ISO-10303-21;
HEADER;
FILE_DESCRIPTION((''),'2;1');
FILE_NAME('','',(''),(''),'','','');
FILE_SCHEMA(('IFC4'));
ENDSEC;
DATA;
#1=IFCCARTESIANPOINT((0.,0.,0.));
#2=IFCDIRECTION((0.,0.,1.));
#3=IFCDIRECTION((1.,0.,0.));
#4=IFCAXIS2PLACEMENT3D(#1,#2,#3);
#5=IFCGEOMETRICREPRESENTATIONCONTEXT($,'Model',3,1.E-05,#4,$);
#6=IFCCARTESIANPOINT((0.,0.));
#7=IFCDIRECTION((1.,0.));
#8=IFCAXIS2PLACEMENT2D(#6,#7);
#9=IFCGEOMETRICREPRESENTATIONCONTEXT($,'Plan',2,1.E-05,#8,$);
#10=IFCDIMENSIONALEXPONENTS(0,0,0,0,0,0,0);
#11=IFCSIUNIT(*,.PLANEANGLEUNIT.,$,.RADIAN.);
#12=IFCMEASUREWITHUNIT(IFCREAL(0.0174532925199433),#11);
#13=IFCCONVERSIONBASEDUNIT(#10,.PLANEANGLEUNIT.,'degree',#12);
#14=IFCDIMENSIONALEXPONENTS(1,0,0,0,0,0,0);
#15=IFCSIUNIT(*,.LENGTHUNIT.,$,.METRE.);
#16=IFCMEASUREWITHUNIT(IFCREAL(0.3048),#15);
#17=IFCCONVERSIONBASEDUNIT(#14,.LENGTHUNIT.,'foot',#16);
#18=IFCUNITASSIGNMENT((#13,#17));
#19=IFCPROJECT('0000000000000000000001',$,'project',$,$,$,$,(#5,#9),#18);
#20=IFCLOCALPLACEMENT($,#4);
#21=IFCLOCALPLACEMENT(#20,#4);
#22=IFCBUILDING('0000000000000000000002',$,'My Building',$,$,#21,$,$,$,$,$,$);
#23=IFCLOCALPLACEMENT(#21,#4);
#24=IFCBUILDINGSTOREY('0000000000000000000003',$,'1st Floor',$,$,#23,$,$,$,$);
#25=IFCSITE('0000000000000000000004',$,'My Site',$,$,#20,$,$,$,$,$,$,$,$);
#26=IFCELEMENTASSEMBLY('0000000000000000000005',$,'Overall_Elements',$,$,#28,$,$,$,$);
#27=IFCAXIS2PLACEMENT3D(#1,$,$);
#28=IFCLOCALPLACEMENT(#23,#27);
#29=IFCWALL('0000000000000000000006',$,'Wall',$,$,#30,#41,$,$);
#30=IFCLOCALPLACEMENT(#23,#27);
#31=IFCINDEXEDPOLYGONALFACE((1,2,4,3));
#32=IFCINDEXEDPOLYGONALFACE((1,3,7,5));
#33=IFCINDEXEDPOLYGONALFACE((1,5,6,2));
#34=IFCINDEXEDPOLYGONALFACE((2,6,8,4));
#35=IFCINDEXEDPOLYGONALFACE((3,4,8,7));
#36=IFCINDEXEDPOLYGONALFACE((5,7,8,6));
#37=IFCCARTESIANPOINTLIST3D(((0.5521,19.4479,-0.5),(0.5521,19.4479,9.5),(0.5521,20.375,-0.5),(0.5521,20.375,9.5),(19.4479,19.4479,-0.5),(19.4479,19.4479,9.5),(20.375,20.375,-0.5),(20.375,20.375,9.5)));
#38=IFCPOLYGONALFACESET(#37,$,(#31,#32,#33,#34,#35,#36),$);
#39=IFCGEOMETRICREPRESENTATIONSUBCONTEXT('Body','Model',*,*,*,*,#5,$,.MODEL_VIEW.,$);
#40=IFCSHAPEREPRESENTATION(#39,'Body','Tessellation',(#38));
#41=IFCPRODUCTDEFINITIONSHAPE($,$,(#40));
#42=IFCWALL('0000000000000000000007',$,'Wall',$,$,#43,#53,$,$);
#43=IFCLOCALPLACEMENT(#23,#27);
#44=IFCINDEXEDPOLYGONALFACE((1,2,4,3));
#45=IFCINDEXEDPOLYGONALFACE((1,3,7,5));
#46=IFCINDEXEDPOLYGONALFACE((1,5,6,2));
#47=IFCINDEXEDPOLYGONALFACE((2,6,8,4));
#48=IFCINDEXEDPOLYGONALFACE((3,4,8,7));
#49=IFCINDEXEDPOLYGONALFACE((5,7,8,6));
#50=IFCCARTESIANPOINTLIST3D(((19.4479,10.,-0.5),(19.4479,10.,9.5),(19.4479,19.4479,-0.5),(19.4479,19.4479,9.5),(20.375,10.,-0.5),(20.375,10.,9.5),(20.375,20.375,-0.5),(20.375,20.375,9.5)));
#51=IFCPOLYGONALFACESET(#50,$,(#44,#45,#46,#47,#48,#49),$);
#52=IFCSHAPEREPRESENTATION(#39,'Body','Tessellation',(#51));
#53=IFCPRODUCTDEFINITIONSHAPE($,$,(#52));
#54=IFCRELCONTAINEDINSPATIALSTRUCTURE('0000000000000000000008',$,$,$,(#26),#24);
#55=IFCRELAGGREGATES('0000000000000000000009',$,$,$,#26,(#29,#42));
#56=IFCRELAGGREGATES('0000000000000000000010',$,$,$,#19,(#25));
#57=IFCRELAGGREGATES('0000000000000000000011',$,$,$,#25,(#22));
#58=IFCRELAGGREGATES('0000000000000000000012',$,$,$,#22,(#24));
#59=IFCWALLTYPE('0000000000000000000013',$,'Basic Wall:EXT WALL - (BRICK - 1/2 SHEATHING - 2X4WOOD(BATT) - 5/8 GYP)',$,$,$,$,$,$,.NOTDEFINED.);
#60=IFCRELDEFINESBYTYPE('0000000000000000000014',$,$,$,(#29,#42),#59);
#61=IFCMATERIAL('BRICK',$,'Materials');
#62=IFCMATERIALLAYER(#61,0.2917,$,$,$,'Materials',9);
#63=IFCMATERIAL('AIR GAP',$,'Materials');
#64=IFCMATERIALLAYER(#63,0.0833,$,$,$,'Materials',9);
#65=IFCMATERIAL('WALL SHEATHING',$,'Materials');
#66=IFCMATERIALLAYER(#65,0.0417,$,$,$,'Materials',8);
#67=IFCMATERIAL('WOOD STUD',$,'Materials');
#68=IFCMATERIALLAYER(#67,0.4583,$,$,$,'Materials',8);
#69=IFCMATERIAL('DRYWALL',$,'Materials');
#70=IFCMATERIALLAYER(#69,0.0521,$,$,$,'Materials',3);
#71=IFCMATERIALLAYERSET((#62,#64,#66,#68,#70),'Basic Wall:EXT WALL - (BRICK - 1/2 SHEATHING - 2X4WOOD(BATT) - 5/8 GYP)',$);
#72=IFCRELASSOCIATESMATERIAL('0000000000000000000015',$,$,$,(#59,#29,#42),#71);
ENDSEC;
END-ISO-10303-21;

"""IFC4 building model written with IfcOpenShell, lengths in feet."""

from ifc_helpers import new_model, entity, si_unit, converted_unit, frame, origin_with_axes, origin_2d_with_axis, place, context, subcontext, project, spatial, indexed_curve, outline, extrude, clip, halfspace, material, layer, layer_set, layer_usage, type_object, element, aggregate, save


model = new_model("IFC4")

# Units and contexts
model_context = context("Model", 3, precision=1e-05, world=origin_with_axes())
plan_context = context("Plan", 2, precision=1e-05, world=origin_2d_with_axis())
body_context = subcontext(model_context, "Body", "Model", "MODEL_VIEW")
ifc_project = project(units=[converted_unit("PLANEANGLEUNIT", "degree", entity("IfcReal", 0.0174532925199433), si_unit("PLANEANGLEUNIT", "RADIAN"), dimensions=[0, 0, 0, 0, 0, 0, 0]), converted_unit("LENGTHUNIT", "foot", entity("IfcReal", 0.3048), si_unit("LENGTHUNIT", "METRE"), dimensions=[1, 0, 0, 0, 0, 0, 0])], contexts=[model_context, plan_context])

# Site, building, storey
site_placement = place(None, origin_with_axes())
site = spatial("IfcSite", under=ifc_project, at=site_placement, Name="My Site")
building_placement = place(site_placement, origin_with_axes())
building = spatial("IfcBuilding", under=site, at=building_placement, Name="My Building")
storey_placement = place(building_placement, origin_with_axes())
storey = spatial("IfcBuildingStorey", under=building, at=storey_placement, Name="1st Floor")

# Element assembly, walls
assembly_placement = place(storey_placement, frame((-0.0833, 0.0256, 9.5), z_axis=(0.0, 0.0, 1.0), x_axis=(1.0, 0.0, 0.0)))
assembly = element("IfcElementAssembly", 1, at=assembly_placement, inside=storey, Name="Overall_Elements")
ifc_material_1 = material(Name="DRYWALL", Category="Materials")
ifc_material_2 = material(Name="BRICK", Category="Materials")
ifc_layer_1 = layer(ifc_material_2, 0.2917, Category="Materials", Priority=9)
ifc_material_3 = material(Name="AIR GAP", Category="Materials")
ifc_layer_2 = layer(ifc_material_3, 0.0833, Category="Materials", Priority=9)
ifc_material_4 = material(Name="WALL SHEATHING", Category="Materials")
ifc_layer_3 = layer(ifc_material_4, 0.0417, Category="Materials", Priority=8)
ifc_material_5 = material(Name="WOOD STUD", Category="Materials")
ifc_layer_4 = layer(ifc_material_5, 0.4583, Category="Materials", Priority=8)
ifc_layer_5 = layer(ifc_material_1, 0.0521, Category="Materials", Priority=3)
ifc_layer_set_1 = layer_set([ifc_layer_1, ifc_layer_2, ifc_layer_3, ifc_layer_4, ifc_layer_5], Name="Basic Wall:EXT WALL - (BRICK - 1/2 SHEATHING - 2X4WOOD(BATT) - 5/8 GYP)")
wall_type_1 = type_object("IfcWallType", Name="Basic Wall:EXT WALL - (BRICK - 1/2 SHEATHING - 2X4WOOD(BATT) - 5/8 GYP)", PredefinedType="NOTDEFINED", material=ifc_layer_set_1)
ifc_layer_usage_1 = layer_usage(ifc_layer_set_1, "AXIS2", "POSITIVE", 0.0)
wall_1_placement = place(assembly_placement, frame((20.4583, 20.3494, -10.0), z_axis=(0.0, 0.0, 1.0), x_axis=(-1.0, 0.0, 0.0)))
wall_1 = element("IfcWall", 2, at=wall_1_placement, type_object=wall_type_1, material=ifc_layer_usage_1, Name="Wall", context=body_context, shape_type="Clipping", body=[
    clip(extrude(outline(indexed_curve([(0.0, 0.0), (0.0, 0.9271), (19.8229, 0.9271), (19.8229, 0.0), (0.0, 0.0)], self_intersect=False)), origin_with_axes(), (0.0, 0.0, 1.0), 10.0), halfspace(frame((0.0, 0.0, 0.5), z_axis=(-0.707107, 0.707106, 0.0), x_axis=(0.707106, 0.707107, 0.0)), False)),
])
ifc_layer_usage_2 = layer_usage(ifc_layer_set_1, "AXIS2", "POSITIVE", 0.0)
wall_2_placement = place(assembly_placement, frame((20.4583, 9.9744, -10.0), z_axis=(0.0, 0.0, 1.0), x_axis=(0.0, 1.0, 0.0)))
wall_2 = element("IfcWall", 3, at=wall_2_placement, type_object=wall_type_1, material=ifc_layer_usage_2, Name="Wall", context=body_context, shape_type="Clipping", body=[
    clip(extrude(outline(indexed_curve([(0.0, 0.0), (0.0, 0.9271), (10.375, 0.9271), (10.375, 0.0), (0.0, 0.0)], self_intersect=False)), origin_with_axes(), (0.0, 0.0, 1.0), 10.0), halfspace(frame((10.375, 0.0, 0.5), z_axis=(0.707107, 0.707107, 0.0), x_axis=(0.707107, -0.707107, 0.0)), False)),
])
aggregate(assembly, [wall_1, wall_2])

save(model, "model.ifc")
